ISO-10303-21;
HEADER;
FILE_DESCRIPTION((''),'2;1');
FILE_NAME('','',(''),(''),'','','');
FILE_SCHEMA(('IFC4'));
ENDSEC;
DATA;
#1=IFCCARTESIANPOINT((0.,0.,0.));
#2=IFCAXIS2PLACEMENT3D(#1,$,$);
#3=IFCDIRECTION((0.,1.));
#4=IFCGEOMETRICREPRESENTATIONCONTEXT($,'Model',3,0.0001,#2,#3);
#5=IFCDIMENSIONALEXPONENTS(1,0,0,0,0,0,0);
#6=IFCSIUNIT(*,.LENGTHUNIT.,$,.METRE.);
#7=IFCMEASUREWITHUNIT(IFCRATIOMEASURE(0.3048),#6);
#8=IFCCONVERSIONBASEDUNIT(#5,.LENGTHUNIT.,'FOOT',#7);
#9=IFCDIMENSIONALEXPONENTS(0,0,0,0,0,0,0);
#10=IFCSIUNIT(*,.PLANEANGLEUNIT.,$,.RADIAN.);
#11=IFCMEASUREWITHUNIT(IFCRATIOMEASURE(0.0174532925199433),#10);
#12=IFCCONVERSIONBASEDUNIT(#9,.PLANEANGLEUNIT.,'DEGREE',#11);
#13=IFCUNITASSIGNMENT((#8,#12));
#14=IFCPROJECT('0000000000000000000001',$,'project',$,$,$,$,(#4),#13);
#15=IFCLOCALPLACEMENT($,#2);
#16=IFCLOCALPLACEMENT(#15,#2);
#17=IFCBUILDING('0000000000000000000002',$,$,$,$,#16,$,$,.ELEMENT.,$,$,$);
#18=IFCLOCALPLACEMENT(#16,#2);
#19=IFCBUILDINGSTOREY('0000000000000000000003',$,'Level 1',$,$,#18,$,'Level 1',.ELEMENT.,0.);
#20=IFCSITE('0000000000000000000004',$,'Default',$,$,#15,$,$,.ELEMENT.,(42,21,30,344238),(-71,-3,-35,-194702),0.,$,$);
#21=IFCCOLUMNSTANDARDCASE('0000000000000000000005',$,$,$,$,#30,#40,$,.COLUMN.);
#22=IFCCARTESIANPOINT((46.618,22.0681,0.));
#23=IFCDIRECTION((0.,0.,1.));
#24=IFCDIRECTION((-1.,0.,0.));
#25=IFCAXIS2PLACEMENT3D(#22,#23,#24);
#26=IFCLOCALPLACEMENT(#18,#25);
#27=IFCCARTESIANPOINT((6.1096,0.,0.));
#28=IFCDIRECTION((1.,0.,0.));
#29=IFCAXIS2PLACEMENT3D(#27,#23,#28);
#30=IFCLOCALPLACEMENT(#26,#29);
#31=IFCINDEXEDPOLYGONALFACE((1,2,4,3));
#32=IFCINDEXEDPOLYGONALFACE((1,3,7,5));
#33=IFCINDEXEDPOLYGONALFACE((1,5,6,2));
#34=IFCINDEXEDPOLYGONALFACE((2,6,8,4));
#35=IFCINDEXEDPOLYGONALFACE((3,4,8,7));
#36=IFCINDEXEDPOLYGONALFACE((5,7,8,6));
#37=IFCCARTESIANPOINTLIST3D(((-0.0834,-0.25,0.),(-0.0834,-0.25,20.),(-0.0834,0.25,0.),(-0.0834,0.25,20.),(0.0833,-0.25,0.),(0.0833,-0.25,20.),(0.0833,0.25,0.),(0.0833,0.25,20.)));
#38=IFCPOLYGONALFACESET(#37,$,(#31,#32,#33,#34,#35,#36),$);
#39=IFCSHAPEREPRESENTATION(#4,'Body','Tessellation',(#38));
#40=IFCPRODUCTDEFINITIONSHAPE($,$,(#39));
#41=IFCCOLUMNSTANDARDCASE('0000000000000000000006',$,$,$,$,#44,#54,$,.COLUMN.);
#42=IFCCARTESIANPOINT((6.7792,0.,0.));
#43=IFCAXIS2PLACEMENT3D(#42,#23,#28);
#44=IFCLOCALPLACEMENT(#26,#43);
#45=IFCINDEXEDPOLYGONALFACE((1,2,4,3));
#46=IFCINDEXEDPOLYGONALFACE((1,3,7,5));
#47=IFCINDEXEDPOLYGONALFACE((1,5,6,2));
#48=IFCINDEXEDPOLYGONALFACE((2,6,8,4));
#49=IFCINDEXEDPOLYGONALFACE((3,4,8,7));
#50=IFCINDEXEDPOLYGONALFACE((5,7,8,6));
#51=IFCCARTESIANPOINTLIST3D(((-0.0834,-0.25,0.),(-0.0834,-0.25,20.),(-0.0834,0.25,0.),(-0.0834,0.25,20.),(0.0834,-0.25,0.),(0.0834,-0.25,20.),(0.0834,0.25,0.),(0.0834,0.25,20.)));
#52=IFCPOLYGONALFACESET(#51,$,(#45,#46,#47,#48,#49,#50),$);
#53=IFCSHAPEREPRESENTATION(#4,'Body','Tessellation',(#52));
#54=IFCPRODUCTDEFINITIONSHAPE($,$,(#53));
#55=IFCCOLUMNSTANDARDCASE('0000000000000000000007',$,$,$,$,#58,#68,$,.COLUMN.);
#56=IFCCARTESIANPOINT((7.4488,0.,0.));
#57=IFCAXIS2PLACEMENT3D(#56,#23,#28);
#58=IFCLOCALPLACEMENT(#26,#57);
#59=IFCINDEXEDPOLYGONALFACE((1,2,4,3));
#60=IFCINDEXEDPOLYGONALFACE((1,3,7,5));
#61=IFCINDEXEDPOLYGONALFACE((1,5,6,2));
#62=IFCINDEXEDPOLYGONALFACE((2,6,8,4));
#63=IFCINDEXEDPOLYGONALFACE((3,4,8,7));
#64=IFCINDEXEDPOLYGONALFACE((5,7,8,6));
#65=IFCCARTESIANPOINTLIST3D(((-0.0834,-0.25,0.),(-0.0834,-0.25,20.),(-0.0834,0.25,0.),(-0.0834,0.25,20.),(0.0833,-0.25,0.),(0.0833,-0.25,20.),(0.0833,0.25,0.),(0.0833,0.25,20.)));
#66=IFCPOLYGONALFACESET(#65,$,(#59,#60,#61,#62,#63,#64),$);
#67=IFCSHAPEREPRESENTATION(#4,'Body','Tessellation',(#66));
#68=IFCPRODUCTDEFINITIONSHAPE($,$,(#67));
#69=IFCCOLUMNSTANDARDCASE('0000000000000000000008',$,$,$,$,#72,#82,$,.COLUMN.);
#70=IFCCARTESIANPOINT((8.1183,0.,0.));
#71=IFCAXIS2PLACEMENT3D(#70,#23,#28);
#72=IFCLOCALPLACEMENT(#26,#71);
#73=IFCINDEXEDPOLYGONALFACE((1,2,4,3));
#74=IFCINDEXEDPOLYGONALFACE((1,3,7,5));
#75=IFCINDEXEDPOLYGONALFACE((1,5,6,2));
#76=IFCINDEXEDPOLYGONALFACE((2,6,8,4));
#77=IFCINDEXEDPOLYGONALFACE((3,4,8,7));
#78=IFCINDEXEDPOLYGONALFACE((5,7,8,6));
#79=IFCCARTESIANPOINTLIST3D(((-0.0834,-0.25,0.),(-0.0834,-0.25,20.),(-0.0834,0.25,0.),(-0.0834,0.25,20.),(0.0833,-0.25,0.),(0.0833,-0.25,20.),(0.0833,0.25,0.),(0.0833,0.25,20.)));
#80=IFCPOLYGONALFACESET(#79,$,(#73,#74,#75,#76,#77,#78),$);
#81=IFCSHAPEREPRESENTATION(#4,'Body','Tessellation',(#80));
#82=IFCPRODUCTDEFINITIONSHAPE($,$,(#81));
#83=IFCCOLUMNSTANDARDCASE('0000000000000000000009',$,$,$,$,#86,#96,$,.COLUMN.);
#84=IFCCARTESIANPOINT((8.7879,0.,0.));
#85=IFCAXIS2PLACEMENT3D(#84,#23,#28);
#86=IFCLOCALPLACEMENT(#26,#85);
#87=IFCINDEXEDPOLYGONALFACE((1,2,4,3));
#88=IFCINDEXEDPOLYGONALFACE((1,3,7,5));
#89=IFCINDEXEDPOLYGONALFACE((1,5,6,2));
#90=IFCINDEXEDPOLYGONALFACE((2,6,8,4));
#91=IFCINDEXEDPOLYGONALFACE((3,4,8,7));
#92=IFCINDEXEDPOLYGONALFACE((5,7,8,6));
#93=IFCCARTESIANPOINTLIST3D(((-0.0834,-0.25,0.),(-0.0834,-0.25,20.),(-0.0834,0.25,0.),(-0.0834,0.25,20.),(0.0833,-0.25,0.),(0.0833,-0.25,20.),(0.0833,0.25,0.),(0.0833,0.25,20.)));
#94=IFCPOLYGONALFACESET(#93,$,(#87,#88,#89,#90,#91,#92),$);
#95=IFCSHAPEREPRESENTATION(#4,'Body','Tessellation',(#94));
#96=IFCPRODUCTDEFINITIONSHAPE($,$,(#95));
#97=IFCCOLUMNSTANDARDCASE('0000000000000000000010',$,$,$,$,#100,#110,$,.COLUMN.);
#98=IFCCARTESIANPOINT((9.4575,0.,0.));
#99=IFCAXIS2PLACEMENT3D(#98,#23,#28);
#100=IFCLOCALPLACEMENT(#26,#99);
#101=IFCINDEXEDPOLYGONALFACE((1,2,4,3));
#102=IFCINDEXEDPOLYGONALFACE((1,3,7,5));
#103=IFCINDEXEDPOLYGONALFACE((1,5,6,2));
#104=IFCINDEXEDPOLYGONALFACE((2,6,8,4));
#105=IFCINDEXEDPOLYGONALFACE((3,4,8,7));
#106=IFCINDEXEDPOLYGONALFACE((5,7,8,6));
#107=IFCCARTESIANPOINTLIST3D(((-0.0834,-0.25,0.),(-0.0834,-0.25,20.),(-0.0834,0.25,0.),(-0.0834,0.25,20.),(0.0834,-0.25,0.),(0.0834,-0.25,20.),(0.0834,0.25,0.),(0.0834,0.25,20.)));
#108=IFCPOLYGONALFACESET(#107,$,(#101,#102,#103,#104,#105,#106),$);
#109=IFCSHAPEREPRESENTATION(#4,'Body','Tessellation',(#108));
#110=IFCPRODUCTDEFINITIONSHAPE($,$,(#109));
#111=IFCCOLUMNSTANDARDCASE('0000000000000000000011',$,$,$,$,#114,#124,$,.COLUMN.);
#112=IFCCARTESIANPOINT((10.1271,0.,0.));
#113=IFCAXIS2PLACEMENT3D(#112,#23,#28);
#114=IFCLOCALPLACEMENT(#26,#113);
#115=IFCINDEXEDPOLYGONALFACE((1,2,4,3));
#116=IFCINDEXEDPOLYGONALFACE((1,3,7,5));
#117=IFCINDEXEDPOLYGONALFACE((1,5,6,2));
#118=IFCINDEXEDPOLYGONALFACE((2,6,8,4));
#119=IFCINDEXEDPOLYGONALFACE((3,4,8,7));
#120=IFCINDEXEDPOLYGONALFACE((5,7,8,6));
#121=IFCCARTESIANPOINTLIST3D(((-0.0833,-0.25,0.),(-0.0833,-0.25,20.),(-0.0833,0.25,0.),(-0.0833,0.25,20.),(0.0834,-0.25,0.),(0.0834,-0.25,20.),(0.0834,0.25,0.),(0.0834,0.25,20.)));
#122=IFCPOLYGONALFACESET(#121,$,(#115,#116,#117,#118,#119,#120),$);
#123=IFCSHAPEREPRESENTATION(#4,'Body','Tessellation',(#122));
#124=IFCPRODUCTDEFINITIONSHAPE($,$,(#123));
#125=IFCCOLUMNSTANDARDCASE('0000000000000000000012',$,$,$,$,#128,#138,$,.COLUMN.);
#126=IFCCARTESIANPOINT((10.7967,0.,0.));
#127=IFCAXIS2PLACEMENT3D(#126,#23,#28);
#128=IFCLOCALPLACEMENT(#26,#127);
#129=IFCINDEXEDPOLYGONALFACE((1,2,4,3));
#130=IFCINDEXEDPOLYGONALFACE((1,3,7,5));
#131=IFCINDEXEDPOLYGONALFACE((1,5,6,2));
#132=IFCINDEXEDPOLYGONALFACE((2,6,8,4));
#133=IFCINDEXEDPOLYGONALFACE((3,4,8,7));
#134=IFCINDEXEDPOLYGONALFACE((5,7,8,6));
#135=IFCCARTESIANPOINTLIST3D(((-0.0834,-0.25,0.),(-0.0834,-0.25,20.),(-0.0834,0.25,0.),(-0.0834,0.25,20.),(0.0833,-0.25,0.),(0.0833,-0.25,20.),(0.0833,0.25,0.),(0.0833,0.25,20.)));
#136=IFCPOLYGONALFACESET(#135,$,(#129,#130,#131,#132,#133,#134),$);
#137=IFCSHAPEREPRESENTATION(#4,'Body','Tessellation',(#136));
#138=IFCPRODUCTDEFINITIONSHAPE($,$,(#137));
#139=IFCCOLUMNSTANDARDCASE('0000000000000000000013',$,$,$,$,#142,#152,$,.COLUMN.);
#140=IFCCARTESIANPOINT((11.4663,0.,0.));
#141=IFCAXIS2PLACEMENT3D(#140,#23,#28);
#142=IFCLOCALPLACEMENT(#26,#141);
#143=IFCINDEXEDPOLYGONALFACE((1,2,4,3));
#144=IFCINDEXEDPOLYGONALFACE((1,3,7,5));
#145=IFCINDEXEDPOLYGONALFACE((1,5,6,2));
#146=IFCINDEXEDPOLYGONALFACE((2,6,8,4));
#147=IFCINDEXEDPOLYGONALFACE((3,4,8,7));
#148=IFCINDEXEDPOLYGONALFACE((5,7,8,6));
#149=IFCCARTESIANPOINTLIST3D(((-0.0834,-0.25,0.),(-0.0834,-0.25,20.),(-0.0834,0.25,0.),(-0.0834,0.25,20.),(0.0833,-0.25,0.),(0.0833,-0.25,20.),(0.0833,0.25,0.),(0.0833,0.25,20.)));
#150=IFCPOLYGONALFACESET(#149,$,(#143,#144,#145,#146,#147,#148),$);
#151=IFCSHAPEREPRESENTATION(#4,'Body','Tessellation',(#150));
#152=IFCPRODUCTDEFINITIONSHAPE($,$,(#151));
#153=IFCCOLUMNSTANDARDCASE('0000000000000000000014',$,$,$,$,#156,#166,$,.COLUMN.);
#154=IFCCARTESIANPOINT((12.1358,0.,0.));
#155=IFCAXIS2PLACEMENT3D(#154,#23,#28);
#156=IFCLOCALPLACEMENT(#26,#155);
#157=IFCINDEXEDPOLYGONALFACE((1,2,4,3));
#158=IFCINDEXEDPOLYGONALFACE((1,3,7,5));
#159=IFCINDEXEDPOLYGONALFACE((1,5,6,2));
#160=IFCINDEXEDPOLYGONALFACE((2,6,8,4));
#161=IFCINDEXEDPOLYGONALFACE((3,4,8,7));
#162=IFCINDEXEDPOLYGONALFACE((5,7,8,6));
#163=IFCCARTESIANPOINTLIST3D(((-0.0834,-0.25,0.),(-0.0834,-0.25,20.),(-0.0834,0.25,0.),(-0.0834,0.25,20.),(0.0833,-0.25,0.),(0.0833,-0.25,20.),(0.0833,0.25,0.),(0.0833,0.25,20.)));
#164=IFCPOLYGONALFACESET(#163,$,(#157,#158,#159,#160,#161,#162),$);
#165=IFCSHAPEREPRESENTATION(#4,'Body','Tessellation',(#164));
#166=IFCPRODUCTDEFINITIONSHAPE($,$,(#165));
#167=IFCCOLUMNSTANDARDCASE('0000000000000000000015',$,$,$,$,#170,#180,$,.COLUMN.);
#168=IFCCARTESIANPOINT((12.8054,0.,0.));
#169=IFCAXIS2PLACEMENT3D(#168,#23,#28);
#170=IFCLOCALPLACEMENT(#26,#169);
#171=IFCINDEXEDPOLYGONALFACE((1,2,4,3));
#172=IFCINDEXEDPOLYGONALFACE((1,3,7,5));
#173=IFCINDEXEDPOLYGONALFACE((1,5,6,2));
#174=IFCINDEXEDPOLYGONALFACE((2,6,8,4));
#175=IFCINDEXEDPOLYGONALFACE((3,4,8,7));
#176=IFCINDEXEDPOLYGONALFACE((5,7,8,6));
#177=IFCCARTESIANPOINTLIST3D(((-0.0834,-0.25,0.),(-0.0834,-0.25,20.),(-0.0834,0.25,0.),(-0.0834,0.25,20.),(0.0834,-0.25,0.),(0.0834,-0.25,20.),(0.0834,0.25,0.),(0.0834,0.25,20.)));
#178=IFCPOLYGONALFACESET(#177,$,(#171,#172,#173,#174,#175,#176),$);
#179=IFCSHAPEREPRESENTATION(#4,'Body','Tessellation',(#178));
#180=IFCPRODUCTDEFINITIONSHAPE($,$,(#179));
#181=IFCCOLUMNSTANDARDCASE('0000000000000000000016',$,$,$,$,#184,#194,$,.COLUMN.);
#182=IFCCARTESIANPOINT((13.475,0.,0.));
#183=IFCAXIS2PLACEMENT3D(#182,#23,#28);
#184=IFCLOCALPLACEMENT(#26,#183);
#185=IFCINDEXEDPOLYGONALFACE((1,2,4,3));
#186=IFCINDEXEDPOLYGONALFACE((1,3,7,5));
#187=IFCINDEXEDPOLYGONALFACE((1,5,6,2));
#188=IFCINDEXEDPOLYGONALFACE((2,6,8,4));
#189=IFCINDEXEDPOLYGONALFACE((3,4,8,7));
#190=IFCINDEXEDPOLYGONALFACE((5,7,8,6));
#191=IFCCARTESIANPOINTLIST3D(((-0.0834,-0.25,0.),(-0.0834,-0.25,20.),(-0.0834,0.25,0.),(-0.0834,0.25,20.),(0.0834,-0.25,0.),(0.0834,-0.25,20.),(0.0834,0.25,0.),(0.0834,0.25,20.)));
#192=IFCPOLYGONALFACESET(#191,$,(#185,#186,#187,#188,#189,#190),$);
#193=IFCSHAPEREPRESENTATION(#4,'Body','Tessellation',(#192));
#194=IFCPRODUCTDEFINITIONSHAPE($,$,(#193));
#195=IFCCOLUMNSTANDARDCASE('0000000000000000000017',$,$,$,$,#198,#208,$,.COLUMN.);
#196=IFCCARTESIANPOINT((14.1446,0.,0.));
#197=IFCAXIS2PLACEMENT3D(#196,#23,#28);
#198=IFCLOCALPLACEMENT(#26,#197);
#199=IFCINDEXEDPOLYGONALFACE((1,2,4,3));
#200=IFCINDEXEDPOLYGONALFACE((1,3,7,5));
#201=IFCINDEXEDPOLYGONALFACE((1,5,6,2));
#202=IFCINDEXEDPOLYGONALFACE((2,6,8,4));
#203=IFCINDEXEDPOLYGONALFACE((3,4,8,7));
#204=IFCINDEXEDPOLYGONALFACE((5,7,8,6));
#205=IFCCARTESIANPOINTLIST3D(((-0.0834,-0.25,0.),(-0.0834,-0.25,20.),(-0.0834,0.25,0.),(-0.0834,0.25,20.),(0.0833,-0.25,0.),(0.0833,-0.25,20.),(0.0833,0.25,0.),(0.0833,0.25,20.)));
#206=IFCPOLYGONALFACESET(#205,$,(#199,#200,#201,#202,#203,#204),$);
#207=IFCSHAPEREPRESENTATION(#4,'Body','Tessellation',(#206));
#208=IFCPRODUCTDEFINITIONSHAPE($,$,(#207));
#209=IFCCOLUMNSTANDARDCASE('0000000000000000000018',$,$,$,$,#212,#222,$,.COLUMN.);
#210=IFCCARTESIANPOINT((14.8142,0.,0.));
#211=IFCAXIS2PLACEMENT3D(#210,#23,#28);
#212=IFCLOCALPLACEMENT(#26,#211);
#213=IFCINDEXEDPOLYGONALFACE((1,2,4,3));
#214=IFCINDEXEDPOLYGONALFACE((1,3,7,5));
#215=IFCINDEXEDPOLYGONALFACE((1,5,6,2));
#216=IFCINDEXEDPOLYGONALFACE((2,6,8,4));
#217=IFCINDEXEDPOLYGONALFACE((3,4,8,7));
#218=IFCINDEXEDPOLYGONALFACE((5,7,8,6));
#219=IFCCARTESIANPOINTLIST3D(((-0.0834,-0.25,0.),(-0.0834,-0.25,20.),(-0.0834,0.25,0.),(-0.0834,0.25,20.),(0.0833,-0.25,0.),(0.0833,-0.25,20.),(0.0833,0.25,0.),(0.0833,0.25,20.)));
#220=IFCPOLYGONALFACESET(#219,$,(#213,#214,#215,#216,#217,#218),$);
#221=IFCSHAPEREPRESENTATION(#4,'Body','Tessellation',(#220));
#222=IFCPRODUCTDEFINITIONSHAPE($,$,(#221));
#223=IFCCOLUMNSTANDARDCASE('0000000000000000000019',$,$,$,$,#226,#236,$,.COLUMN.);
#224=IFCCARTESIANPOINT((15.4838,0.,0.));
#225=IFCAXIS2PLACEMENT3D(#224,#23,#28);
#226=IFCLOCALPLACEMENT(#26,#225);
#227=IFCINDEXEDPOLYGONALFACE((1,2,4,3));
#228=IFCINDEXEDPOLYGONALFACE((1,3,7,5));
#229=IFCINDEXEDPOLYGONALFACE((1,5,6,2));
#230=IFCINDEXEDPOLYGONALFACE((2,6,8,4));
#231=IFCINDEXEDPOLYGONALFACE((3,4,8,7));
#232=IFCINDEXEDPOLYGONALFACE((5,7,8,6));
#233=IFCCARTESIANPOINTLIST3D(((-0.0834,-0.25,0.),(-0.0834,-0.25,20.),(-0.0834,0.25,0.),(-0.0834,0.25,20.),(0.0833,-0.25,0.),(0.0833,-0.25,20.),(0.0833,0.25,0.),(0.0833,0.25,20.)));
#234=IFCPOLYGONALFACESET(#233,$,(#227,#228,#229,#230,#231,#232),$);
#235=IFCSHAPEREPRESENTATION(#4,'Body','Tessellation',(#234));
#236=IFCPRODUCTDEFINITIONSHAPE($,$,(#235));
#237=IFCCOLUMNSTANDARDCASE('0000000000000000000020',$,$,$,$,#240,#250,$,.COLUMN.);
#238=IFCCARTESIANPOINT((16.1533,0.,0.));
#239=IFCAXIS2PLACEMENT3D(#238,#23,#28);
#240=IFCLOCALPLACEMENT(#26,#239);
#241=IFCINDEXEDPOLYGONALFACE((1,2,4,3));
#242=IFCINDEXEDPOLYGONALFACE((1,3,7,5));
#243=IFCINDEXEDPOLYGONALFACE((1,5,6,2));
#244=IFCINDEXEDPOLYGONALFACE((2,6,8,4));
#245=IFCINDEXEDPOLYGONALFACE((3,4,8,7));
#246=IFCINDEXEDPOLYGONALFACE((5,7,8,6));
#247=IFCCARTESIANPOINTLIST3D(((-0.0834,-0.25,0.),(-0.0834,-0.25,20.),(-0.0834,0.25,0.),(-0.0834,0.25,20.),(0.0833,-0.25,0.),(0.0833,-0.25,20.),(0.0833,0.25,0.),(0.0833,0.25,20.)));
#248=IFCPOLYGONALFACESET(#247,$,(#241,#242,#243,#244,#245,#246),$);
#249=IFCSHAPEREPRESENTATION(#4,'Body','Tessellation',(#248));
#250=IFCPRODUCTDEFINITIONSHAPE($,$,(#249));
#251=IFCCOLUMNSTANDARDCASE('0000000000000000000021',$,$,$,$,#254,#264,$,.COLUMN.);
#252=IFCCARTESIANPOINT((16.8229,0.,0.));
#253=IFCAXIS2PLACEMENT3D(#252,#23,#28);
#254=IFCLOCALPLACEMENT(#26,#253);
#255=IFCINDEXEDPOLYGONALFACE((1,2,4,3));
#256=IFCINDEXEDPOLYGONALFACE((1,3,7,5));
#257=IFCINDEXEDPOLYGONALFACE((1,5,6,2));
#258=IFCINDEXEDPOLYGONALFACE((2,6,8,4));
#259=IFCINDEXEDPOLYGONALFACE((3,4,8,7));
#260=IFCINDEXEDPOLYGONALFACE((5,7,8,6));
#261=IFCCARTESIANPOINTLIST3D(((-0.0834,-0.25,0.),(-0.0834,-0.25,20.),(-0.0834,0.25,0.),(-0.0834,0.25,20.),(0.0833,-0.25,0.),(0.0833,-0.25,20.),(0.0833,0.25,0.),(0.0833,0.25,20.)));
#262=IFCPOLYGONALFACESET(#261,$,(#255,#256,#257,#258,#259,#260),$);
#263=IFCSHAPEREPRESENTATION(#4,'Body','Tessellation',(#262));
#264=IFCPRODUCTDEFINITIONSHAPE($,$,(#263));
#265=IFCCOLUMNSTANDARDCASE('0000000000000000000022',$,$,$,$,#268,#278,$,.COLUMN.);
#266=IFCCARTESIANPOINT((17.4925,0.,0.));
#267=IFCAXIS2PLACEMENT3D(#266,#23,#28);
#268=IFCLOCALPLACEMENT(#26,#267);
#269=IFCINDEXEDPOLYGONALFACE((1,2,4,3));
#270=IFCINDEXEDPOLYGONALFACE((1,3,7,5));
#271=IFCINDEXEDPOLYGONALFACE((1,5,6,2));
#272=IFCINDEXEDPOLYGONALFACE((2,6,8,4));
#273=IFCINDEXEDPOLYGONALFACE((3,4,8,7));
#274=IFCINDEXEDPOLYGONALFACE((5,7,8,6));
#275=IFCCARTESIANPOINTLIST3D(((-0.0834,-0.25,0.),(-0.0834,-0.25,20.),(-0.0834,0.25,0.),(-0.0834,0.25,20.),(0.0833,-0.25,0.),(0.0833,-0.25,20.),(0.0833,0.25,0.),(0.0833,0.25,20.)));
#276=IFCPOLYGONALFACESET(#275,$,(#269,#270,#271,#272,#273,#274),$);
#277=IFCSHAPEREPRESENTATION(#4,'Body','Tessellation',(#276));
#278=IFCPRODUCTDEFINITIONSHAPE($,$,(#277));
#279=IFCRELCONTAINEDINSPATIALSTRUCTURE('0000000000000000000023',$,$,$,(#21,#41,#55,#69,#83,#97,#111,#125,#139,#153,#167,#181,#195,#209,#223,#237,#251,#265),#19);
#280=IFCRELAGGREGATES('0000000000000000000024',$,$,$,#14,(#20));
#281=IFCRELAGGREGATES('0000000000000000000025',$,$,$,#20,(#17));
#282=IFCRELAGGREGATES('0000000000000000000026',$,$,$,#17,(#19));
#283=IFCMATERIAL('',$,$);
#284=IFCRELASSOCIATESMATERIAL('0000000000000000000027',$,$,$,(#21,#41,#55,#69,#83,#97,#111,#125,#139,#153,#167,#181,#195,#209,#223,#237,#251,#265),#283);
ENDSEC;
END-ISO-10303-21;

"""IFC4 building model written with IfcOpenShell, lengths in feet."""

from ifc_helpers import new_model, entity, si_unit, converted_unit, direction, frame, origin, place, context, project, spatial, rectangle, extrude, material, element, save


model = new_model("IFC4")

# Units and contexts
model_context = context("Model", 3, precision=0.0001, world=origin(), true_north=direction((0.0, 1.0)))
ifc_project = project(units=[converted_unit("LENGTHUNIT", "FOOT", entity("IfcRatioMeasure", 0.3048), si_unit("LENGTHUNIT", "METRE"), dimensions=[1, 0, 0, 0, 0, 0, 0]), converted_unit("PLANEANGLEUNIT", "DEGREE", entity("IfcRatioMeasure", 0.0174532925199433), si_unit("PLANEANGLEUNIT", "RADIAN"), dimensions=[0, 0, 0, 0, 0, 0, 0])], contexts=[model_context])

# Site, building, storey
site_placement = place(None, origin())
site = spatial("IfcSite", under=ifc_project, at=site_placement, Name="Default", CompositionType="ELEMENT", RefLatitude=(42, 21, 30, 344238), RefLongitude=(-71, -3, -35, -194702), RefElevation=0.0)
building_placement = place(site_placement, origin())
building = spatial("IfcBuilding", under=site, at=building_placement, CompositionType="ELEMENT")
storey_placement = place(building_placement, origin())
storey = spatial("IfcBuildingStorey", under=building, at=storey_placement, Name="Level 1", LongName="Level 1", CompositionType="ELEMENT", Elevation=0.0)

# Columns
ifc_material = material(Name="")
placement = place(storey_placement, frame((46.618, 22.0681, 0.0), z_axis=(0.0, 0.0, 1.0), x_axis=(-1.0, 0.0, 0.0)))
for number, where, z_axis, x_axis in (
    (1, (6.1096, 0.0, 0.0), (0.0, 0.0, 1.0), (1.0, 0.0, 0.0)),
    (2, (6.7792, 0.0, 0.0), (0.0, 0.0, 1.0), (1.0, 0.0, 0.0)),
    (3, (7.4488, 0.0, 0.0), (0.0, 0.0, 1.0), (1.0, 0.0, 0.0)),
    (4, (8.1183, 0.0, 0.0), (0.0, 0.0, 1.0), (1.0, 0.0, 0.0)),
    (5, (8.7879, 0.0, 0.0), (0.0, 0.0, 1.0), (1.0, 0.0, 0.0)),
    (6, (9.4575, 0.0, 0.0), (0.0, 0.0, 1.0), (1.0, 0.0, 0.0)),
    (7, (10.1271, 0.0, 0.0), (0.0, 0.0, 1.0), (1.0, 0.0, 0.0)),
    (8, (10.7967, 0.0, 0.0), (0.0, 0.0, 1.0), (1.0, 0.0, 0.0)),
    (9, (11.4663, 0.0, 0.0), (0.0, 0.0, 1.0), (1.0, 0.0, 0.0)),
    (10, (12.1358, 0.0, 0.0), (0.0, 0.0, 1.0), (1.0, 0.0, 0.0)),
    (11, (12.8054, 0.0, 0.0), (0.0, 0.0, 1.0), (1.0, 0.0, 0.0)),
    (12, (13.475, 0.0, 0.0), (0.0, 0.0, 1.0), (1.0, 0.0, 0.0)),
    (13, (14.1446, 0.0, 0.0), (0.0, 0.0, 1.0), (1.0, 0.0, 0.0)),
    (14, (14.8142, 0.0, 0.0), (0.0, 0.0, 1.0), (1.0, 0.0, 0.0)),
    (15, (15.4838, 0.0, 0.0), (0.0, 0.0, 1.0), (1.0, 0.0, 0.0)),
    (16, (16.1533, 0.0, 0.0), (0.0, 0.0, 1.0), (1.0, 0.0, 0.0)),
    (17, (16.8229, 0.0, 0.0), (0.0, 0.0, 1.0), (1.0, 0.0, 0.0)),
    (18, (17.4925, 0.0, 0.0), (0.0, 0.0, 1.0), (1.0, 0.0, 0.0)),
):
    element("IfcColumnStandardCase", number, at=place(placement, frame(where, z_axis=z_axis, x_axis=x_axis)), inside=storey, material=ifc_material, PredefinedType="COLUMN", context=model_context, shape_type="SweptSolid", body=[
        extrude(rectangle(XDim=0.1667, YDim=0.5), origin(), (0.0, 0.0, 1.0), 20.0),
    ])

save(model, "model.ifc")
